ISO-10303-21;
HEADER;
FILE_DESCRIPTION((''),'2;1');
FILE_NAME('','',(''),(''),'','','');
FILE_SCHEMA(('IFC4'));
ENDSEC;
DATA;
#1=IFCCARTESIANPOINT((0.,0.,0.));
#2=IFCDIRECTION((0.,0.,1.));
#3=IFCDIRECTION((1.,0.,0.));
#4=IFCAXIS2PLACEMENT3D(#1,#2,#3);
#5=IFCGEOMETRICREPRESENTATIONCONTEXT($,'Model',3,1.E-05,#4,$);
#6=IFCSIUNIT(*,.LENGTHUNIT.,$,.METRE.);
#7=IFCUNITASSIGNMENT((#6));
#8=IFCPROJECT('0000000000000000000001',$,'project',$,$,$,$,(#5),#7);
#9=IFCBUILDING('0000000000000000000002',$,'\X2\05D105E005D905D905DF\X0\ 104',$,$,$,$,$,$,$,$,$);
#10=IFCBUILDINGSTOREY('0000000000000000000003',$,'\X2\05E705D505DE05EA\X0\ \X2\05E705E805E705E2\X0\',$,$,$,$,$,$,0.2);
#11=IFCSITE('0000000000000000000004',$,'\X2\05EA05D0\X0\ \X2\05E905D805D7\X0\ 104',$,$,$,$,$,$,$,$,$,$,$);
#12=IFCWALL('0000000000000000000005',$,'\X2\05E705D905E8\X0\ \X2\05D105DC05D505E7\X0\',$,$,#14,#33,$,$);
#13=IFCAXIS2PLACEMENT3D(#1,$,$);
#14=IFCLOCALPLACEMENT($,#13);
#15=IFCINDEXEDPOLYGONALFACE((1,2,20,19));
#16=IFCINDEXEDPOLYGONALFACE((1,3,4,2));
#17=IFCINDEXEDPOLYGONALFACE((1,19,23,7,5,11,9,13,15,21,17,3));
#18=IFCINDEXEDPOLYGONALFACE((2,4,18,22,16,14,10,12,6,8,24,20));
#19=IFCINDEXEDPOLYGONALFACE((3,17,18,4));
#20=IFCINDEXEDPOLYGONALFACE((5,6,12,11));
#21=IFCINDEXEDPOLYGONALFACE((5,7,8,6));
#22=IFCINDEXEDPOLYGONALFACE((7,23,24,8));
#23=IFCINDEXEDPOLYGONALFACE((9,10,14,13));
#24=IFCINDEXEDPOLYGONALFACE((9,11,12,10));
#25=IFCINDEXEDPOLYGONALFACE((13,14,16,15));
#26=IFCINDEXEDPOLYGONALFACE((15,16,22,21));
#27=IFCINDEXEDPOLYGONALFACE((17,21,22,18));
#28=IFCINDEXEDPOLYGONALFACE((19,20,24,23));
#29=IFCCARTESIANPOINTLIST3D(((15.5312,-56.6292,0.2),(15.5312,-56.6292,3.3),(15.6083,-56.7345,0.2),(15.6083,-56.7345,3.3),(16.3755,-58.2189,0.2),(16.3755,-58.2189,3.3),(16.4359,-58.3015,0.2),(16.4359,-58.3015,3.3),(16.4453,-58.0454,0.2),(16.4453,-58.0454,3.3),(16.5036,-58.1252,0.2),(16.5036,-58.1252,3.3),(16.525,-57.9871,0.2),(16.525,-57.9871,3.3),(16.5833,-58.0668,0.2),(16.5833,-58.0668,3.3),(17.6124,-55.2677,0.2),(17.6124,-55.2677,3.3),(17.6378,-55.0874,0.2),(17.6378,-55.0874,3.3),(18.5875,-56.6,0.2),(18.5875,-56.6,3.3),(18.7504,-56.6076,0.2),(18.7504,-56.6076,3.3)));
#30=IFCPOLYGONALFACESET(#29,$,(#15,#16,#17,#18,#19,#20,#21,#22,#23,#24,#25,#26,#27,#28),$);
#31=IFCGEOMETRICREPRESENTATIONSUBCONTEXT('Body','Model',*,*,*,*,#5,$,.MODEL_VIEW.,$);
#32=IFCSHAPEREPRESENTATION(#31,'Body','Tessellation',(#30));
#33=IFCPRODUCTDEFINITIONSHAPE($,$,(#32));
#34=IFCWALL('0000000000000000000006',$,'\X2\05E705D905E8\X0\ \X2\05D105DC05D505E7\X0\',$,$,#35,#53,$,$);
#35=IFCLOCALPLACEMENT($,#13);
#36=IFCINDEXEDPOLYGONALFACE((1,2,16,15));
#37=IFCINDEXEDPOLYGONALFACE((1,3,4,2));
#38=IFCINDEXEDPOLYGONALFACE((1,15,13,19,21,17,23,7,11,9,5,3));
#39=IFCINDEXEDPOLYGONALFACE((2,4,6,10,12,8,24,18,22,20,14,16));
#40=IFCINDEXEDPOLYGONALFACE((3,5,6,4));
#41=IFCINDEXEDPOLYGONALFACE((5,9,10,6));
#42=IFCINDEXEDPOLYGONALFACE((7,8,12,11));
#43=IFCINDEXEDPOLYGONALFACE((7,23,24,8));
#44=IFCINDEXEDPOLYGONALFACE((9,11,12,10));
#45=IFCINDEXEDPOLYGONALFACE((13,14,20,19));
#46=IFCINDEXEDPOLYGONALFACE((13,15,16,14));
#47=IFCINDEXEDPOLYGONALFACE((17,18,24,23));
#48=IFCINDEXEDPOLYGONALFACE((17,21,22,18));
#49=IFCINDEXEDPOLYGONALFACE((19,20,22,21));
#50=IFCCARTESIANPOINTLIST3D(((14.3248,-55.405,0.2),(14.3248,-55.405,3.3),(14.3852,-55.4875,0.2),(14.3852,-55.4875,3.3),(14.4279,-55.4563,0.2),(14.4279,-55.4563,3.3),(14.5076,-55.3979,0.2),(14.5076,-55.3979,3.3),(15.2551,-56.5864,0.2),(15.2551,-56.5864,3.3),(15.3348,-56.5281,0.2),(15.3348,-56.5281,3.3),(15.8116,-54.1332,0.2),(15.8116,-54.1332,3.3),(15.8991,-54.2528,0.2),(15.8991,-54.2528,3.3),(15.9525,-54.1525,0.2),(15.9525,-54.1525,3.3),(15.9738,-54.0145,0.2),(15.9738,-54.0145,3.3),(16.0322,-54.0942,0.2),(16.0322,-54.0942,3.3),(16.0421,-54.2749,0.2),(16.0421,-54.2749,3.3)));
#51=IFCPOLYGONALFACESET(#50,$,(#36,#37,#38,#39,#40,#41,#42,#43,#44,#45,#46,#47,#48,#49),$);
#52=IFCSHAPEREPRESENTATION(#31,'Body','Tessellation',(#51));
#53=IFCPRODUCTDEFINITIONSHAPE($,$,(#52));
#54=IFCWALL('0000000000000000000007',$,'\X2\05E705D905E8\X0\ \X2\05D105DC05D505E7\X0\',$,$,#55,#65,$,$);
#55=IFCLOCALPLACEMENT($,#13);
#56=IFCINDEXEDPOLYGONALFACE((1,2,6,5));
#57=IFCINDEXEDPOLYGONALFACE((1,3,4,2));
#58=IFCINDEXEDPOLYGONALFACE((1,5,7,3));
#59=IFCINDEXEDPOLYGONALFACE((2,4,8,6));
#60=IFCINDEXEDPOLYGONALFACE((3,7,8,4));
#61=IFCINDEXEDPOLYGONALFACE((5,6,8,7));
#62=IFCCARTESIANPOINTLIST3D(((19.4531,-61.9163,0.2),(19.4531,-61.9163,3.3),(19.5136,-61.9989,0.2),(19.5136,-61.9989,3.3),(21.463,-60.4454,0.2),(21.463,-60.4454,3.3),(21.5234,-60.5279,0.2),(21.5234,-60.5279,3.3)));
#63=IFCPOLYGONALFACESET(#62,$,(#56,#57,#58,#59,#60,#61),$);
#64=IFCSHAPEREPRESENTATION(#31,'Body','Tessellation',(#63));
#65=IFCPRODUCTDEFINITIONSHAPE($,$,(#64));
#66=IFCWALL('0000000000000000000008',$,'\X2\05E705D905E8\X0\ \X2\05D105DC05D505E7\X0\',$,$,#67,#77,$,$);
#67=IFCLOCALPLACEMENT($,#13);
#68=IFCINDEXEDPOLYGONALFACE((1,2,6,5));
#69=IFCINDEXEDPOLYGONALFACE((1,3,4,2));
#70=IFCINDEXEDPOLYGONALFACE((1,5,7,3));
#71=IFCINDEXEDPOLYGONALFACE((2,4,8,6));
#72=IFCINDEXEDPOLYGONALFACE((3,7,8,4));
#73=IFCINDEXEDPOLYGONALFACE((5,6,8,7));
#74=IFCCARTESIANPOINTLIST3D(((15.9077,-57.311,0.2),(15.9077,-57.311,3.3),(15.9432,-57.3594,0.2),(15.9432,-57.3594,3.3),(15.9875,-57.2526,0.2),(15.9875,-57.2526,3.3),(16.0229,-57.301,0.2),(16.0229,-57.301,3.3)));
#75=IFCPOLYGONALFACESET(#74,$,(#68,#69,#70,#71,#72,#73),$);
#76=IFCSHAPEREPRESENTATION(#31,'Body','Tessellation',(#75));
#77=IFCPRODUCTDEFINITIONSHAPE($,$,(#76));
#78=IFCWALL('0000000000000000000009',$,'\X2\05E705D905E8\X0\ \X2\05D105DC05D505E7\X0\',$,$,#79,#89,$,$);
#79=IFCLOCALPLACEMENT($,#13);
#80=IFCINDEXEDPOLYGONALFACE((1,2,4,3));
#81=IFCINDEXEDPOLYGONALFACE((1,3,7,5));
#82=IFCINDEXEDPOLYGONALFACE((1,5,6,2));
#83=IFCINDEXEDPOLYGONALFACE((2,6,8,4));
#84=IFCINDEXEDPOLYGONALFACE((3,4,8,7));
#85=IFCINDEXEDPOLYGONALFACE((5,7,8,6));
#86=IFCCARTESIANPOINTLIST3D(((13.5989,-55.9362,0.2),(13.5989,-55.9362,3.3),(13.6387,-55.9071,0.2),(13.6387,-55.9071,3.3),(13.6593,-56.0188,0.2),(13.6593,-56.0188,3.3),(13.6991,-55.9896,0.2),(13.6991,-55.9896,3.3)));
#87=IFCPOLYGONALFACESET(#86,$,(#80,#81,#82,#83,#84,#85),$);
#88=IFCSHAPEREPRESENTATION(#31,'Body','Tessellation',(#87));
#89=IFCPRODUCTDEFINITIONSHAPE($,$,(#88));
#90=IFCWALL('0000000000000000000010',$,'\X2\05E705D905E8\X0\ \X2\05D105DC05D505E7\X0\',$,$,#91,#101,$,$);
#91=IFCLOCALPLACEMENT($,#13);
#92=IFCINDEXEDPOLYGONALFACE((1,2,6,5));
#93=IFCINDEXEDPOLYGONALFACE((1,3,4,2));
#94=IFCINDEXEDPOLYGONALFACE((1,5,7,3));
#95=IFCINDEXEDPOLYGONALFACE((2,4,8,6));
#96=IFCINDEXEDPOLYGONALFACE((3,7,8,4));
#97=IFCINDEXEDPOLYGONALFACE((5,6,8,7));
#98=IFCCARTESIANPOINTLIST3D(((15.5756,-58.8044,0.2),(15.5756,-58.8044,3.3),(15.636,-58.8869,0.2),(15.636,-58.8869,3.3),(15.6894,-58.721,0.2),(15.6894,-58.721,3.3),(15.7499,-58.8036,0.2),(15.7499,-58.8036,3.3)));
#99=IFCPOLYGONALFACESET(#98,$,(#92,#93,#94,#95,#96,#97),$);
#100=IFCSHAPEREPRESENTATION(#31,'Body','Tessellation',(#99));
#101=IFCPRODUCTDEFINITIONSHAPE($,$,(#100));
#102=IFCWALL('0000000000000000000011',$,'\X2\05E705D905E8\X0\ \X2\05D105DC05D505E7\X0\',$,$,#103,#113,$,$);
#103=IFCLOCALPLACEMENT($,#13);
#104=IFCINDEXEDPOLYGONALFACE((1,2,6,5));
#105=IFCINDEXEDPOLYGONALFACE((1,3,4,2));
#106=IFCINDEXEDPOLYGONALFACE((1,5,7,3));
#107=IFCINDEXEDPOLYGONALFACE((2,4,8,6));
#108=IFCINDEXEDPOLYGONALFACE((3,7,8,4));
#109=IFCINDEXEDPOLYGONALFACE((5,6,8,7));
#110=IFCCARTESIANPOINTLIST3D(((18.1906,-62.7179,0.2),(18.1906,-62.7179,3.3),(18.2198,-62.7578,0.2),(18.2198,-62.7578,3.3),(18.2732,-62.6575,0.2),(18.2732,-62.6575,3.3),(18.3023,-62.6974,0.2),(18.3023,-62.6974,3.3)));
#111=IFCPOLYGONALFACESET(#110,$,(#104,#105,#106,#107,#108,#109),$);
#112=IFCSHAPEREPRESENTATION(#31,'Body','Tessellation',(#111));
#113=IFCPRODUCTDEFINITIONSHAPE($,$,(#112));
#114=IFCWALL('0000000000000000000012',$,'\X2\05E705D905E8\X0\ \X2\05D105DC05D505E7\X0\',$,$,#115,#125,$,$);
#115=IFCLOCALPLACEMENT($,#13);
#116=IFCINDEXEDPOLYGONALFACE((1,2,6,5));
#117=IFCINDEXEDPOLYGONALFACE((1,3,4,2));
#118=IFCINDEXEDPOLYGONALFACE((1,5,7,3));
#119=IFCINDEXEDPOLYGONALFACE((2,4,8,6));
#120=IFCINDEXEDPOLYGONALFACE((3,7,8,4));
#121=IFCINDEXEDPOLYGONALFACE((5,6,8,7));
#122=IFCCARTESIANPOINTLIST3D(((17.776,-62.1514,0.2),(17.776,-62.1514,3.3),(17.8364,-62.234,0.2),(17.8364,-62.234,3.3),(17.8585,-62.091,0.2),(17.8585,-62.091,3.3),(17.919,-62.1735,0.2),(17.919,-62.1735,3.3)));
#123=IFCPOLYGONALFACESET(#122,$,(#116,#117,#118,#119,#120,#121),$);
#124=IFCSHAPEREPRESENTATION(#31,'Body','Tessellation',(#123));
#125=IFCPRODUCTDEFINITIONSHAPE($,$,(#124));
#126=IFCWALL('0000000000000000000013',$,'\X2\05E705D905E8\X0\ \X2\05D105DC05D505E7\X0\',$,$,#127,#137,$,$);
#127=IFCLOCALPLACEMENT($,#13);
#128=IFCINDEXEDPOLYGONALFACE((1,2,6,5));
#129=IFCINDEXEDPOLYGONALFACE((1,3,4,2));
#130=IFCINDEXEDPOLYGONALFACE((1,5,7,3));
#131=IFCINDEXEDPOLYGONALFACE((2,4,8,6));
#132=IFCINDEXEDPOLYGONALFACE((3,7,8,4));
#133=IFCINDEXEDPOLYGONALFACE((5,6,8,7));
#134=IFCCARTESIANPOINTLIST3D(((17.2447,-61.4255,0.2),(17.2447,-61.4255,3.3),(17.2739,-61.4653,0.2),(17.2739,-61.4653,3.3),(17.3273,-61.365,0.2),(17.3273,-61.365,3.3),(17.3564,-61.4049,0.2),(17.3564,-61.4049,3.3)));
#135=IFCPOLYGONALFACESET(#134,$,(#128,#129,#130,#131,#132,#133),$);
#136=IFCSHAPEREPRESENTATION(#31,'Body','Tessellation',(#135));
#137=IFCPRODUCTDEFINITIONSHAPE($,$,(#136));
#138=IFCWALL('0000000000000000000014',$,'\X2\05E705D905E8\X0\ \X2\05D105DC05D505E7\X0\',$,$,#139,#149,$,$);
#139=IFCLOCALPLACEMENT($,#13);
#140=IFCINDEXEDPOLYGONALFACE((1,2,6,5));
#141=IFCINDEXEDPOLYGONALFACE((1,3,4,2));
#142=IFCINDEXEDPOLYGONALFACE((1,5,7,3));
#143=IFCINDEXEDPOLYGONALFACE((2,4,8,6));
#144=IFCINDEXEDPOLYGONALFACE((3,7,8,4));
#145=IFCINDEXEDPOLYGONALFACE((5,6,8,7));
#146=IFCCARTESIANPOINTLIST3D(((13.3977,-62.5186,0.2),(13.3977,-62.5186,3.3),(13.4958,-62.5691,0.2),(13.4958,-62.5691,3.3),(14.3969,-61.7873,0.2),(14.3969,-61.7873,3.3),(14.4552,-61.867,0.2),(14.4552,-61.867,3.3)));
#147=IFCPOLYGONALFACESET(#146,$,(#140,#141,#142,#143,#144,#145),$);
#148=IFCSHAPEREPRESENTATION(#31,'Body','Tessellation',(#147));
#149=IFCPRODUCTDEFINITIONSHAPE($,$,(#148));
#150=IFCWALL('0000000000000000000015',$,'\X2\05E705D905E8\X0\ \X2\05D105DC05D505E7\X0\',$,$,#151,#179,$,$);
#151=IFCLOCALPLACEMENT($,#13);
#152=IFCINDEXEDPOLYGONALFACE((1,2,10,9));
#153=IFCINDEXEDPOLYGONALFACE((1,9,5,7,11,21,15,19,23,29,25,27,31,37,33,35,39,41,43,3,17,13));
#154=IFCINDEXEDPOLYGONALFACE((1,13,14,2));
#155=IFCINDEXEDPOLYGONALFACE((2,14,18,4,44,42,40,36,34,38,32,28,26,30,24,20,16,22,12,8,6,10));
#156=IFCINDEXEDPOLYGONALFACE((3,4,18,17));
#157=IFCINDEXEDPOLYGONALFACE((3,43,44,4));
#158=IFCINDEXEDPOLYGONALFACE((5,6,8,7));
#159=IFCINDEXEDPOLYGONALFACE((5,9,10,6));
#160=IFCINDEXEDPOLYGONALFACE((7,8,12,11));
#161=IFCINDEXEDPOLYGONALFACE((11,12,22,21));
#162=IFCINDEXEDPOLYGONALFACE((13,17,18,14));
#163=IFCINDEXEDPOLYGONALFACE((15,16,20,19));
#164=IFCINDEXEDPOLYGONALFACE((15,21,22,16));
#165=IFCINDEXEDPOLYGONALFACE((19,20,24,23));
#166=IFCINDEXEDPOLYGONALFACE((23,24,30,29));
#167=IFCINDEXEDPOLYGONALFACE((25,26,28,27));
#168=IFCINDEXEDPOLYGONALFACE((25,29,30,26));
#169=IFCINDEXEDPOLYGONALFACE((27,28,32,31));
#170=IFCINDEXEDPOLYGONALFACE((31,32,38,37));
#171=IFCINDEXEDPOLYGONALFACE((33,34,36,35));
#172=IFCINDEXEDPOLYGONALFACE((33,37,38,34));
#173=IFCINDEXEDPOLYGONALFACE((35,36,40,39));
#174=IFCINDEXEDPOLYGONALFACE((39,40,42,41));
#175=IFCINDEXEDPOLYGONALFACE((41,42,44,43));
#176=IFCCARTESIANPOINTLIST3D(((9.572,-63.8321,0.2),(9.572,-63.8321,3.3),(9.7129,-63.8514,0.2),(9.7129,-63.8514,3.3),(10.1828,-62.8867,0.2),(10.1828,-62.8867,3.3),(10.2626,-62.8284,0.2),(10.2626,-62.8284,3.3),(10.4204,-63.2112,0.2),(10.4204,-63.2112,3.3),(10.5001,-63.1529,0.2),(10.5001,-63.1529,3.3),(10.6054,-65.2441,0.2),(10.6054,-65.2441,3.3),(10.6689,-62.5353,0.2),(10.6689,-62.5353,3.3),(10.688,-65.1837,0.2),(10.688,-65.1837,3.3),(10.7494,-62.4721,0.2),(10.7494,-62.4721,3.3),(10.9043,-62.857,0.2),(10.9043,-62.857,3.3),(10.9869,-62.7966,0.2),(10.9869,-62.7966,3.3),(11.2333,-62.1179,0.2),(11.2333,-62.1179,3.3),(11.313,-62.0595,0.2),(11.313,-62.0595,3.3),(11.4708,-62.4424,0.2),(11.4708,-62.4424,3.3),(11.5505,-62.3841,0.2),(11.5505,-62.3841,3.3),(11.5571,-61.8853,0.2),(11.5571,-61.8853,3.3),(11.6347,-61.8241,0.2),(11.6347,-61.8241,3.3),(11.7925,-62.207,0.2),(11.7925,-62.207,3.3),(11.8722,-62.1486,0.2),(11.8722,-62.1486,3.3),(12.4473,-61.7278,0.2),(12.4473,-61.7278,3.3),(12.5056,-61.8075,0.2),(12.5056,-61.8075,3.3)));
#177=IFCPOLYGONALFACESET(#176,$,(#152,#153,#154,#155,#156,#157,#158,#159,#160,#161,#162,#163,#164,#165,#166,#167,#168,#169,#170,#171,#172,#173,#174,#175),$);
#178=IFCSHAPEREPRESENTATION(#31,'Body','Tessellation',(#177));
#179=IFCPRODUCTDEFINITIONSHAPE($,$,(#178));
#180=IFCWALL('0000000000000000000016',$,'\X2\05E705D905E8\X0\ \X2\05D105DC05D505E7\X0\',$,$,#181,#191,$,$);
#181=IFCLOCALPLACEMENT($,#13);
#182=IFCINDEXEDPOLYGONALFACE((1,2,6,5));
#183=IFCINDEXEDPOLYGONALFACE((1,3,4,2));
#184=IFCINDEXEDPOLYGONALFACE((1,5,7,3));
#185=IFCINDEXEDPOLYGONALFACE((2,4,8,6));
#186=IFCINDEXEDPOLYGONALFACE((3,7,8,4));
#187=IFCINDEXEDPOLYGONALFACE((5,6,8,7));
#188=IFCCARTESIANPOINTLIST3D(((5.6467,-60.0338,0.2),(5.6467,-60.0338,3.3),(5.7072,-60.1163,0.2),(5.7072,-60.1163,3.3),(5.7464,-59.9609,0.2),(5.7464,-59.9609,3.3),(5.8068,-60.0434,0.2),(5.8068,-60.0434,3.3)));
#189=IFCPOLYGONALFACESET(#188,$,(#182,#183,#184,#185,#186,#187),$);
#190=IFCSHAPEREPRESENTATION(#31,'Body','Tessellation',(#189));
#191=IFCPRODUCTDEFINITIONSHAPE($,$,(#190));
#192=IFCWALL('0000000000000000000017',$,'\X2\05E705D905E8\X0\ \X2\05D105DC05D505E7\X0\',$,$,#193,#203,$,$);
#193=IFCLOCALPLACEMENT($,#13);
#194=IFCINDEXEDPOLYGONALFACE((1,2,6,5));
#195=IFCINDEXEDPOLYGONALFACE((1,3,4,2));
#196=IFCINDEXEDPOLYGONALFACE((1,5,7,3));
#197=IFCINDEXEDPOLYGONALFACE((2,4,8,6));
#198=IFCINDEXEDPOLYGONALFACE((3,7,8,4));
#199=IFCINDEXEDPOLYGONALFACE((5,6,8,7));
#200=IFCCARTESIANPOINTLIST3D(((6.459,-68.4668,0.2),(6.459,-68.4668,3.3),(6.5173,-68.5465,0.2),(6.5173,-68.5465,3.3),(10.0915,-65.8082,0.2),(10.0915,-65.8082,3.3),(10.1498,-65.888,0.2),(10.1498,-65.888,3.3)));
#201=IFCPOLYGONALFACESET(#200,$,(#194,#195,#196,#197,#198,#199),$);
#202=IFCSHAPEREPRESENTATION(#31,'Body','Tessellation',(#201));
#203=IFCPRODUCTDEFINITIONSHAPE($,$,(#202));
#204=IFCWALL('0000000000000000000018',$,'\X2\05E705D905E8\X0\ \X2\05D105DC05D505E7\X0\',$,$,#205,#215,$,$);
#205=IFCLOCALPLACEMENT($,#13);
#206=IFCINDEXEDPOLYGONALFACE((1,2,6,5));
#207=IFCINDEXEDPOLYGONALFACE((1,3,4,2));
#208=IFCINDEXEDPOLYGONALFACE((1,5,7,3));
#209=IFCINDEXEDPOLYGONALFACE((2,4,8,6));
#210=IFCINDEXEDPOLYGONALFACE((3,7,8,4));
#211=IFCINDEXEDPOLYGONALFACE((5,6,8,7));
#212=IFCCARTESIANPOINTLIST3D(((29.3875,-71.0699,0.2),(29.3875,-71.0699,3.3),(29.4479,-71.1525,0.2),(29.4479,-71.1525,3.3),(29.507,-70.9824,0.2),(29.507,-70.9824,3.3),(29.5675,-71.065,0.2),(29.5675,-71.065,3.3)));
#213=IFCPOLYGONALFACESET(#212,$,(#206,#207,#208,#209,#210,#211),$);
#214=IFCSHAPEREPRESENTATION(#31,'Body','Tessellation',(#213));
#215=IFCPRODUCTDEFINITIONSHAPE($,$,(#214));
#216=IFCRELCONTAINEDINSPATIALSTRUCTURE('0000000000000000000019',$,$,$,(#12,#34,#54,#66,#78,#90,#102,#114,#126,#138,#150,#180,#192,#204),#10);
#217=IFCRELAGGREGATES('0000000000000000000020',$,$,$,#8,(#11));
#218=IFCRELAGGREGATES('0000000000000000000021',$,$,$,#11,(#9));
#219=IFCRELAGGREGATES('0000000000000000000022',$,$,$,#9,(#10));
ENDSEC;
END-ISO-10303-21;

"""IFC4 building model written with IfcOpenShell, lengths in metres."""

from ifc_helpers import new_model, si_unit, frame, origin_with_axes, context, subcontext, project, spatial, polyline, outline, extrude, element, save


model = new_model("IFC4")

# Units and contexts
model_context = context("Model", 3, precision=1e-05, world=origin_with_axes())
body_context = subcontext(model_context, "Body", "Model", "MODEL_VIEW")
ifc_project = project(units=[si_unit("LENGTHUNIT", "METRE")], contexts=[model_context])

# Site, building, storey
site = spatial("IfcSite", under=ifc_project, Name="תא שטח 104")
building = spatial("IfcBuilding", under=site, Name="בניין 104")
storey = spatial("IfcBuildingStorey", under=building, Name="קומת קרקע", Elevation=0.2)

# Walls
element("IfcWall", 1, inside=storey, Name="קיר בלוק", context=body_context, shape_type="SweptSolid", body=[
    extrude(outline(polyline([(16.525, -57.9871), (16.4453, -58.0454), (16.5036, -58.1252), (16.3755, -58.2189), (16.4359, -58.3015), (18.7504, -56.6076), (17.6378, -55.0874), (15.5312, -56.6292), (15.6083, -56.7345), (17.6124, -55.2677), (18.5875, -56.6), (16.5833, -58.0668), (16.525, -57.9871)])), frame((0.0, 0.0, 0.2)), (0.0, 0.0, 1.0), 3.1),
])
element("IfcWall", 2, inside=storey, Name="קיר בלוק", context=body_context, shape_type="SweptSolid", body=[
    extrude(outline(polyline([(15.8991, -54.2528), (14.3248, -55.405), (14.3852, -55.4875), (14.4279, -55.4563), (15.2551, -56.5864), (15.3348, -56.5281), (14.5076, -55.3979), (16.0421, -54.2749), (15.9525, -54.1525), (16.0322, -54.0942), (15.9738, -54.0145), (15.8116, -54.1332), (15.8991, -54.2528)])), frame((0.0, 0.0, 0.2)), (0.0, 0.0, 1.0), 3.1),
])
element("IfcWall", 3, inside=storey, Name="קיר בלוק", context=body_context, shape_type="SweptSolid", body=[
    extrude(outline(polyline([(21.5234, -60.5279), (21.463, -60.4454), (19.4531, -61.9163), (19.5136, -61.9989), (21.5234, -60.5279)])), frame((0.0, 0.0, 0.2)), (0.0, 0.0, 1.0), 3.1),
])
element("IfcWall", 4, inside=storey, Name="קיר בלוק", context=body_context, shape_type="SweptSolid", body=[
    extrude(outline(polyline([(15.9077, -57.311), (15.9432, -57.3594), (16.0229, -57.301), (15.9875, -57.2526), (15.9077, -57.311)])), frame((0.0, 0.0, 0.2)), (0.0, 0.0, 1.0), 3.1),
])
element("IfcWall", 5, inside=storey, Name="קיר בלוק", context=body_context, shape_type="SweptSolid", body=[
    extrude(outline(polyline([(13.6991, -55.9896), (13.6387, -55.9071), (13.5989, -55.9362), (13.6593, -56.0188), (13.6991, -55.9896)])), frame((0.0, 0.0, 0.2)), (0.0, 0.0, 1.0), 3.1),
])
element("IfcWall", 6, inside=storey, Name="קיר בלוק", context=body_context, shape_type="SweptSolid", body=[
    extrude(outline(polyline([(15.6894, -58.721), (15.5756, -58.8044), (15.636, -58.8869), (15.7499, -58.8036), (15.6894, -58.721)])), frame((0.0, 0.0, 0.2)), (0.0, 0.0, 1.0), 3.1),
])
element("IfcWall", 7, inside=storey, Name="קיר בלוק", context=body_context, shape_type="SweptSolid", body=[
    extrude(outline(polyline([(18.3023, -62.6974), (18.2732, -62.6575), (18.1906, -62.7179), (18.2198, -62.7578), (18.3023, -62.6974)])), frame((0.0, 0.0, 0.2)), (0.0, 0.0, 1.0), 3.1),
])
element("IfcWall", 8, inside=storey, Name="קיר בלוק", context=body_context, shape_type="SweptSolid", body=[
    extrude(outline(polyline([(17.919, -62.1735), (17.8585, -62.091), (17.776, -62.1514), (17.8364, -62.234), (17.919, -62.1735)])), frame((0.0, 0.0, 0.2)), (0.0, 0.0, 1.0), 3.1),
])
element("IfcWall", 9, inside=storey, Name="קיר בלוק", context=body_context, shape_type="SweptSolid", body=[
    extrude(outline(polyline([(17.3273, -61.365), (17.2447, -61.4255), (17.2739, -61.4653), (17.3564, -61.4049), (17.3273, -61.365)])), frame((0.0, 0.0, 0.2)), (0.0, 0.0, 1.0), 3.1),
])
element("IfcWall", 10, inside=storey, Name="קיר בלוק", context=body_context, shape_type="SweptSolid", body=[
    extrude(outline(polyline([(13.4958, -62.5691), (14.4552, -61.867), (14.3969, -61.7873), (13.3977, -62.5186), (13.4958, -62.5691)])), frame((0.0, 0.0, 0.2)), (0.0, 0.0, 1.0), 3.1),
])
element("IfcWall", 11, inside=storey, Name="קיר בלוק", context=body_context, shape_type="SweptSolid", body=[
    extrude(outline(polyline([(11.2333, -62.1179), (11.4708, -62.4424), (10.9869, -62.7966), (10.7494, -62.4721), (10.6689, -62.5353), (10.9043, -62.857), (10.5001, -63.1529), (10.2626, -62.8284), (10.1828, -62.8867), (10.4204, -63.2112), (9.572, -63.8321), (10.6054, -65.2441), (10.688, -65.1837), (9.7129, -63.8514), (12.5056, -61.8075), (12.4473, -61.7278), (11.8722, -62.1486), (11.6347, -61.8241), (11.5571, -61.8853), (11.7925, -62.207), (11.5505, -62.3841), (11.313, -62.0595), (11.2333, -62.1179)])), frame((0.0, 0.0, 0.2)), (0.0, 0.0, 1.0), 3.1),
])
element("IfcWall", 12, inside=storey, Name="קיר בלוק", context=body_context, shape_type="SweptSolid", body=[
    extrude(outline(polyline([(5.7072, -60.1163), (5.8068, -60.0434), (5.7464, -59.9609), (5.6467, -60.0338), (5.7072, -60.1163)])), frame((0.0, 0.0, 0.2)), (0.0, 0.0, 1.0), 3.1),
])
element("IfcWall", 13, inside=storey, Name="קיר בלוק", context=body_context, shape_type="SweptSolid", body=[
    extrude(outline(polyline([(6.459, -68.4668), (6.5173, -68.5465), (10.1498, -65.888), (10.0915, -65.8082), (6.459, -68.4668)])), frame((0.0, 0.0, 0.2)), (0.0, 0.0, 1.0), 3.1),
])
element("IfcWall", 14, inside=storey, Name="קיר בלוק", context=body_context, shape_type="SweptSolid", body=[
    extrude(outline(polyline([(29.5675, -71.065), (29.507, -70.9824), (29.3875, -71.0699), (29.4479, -71.1525), (29.5675, -71.065)])), frame((0.0, 0.0, 0.2)), (0.0, 0.0, 1.0), 3.1),
])

save(model, "model.ifc")
